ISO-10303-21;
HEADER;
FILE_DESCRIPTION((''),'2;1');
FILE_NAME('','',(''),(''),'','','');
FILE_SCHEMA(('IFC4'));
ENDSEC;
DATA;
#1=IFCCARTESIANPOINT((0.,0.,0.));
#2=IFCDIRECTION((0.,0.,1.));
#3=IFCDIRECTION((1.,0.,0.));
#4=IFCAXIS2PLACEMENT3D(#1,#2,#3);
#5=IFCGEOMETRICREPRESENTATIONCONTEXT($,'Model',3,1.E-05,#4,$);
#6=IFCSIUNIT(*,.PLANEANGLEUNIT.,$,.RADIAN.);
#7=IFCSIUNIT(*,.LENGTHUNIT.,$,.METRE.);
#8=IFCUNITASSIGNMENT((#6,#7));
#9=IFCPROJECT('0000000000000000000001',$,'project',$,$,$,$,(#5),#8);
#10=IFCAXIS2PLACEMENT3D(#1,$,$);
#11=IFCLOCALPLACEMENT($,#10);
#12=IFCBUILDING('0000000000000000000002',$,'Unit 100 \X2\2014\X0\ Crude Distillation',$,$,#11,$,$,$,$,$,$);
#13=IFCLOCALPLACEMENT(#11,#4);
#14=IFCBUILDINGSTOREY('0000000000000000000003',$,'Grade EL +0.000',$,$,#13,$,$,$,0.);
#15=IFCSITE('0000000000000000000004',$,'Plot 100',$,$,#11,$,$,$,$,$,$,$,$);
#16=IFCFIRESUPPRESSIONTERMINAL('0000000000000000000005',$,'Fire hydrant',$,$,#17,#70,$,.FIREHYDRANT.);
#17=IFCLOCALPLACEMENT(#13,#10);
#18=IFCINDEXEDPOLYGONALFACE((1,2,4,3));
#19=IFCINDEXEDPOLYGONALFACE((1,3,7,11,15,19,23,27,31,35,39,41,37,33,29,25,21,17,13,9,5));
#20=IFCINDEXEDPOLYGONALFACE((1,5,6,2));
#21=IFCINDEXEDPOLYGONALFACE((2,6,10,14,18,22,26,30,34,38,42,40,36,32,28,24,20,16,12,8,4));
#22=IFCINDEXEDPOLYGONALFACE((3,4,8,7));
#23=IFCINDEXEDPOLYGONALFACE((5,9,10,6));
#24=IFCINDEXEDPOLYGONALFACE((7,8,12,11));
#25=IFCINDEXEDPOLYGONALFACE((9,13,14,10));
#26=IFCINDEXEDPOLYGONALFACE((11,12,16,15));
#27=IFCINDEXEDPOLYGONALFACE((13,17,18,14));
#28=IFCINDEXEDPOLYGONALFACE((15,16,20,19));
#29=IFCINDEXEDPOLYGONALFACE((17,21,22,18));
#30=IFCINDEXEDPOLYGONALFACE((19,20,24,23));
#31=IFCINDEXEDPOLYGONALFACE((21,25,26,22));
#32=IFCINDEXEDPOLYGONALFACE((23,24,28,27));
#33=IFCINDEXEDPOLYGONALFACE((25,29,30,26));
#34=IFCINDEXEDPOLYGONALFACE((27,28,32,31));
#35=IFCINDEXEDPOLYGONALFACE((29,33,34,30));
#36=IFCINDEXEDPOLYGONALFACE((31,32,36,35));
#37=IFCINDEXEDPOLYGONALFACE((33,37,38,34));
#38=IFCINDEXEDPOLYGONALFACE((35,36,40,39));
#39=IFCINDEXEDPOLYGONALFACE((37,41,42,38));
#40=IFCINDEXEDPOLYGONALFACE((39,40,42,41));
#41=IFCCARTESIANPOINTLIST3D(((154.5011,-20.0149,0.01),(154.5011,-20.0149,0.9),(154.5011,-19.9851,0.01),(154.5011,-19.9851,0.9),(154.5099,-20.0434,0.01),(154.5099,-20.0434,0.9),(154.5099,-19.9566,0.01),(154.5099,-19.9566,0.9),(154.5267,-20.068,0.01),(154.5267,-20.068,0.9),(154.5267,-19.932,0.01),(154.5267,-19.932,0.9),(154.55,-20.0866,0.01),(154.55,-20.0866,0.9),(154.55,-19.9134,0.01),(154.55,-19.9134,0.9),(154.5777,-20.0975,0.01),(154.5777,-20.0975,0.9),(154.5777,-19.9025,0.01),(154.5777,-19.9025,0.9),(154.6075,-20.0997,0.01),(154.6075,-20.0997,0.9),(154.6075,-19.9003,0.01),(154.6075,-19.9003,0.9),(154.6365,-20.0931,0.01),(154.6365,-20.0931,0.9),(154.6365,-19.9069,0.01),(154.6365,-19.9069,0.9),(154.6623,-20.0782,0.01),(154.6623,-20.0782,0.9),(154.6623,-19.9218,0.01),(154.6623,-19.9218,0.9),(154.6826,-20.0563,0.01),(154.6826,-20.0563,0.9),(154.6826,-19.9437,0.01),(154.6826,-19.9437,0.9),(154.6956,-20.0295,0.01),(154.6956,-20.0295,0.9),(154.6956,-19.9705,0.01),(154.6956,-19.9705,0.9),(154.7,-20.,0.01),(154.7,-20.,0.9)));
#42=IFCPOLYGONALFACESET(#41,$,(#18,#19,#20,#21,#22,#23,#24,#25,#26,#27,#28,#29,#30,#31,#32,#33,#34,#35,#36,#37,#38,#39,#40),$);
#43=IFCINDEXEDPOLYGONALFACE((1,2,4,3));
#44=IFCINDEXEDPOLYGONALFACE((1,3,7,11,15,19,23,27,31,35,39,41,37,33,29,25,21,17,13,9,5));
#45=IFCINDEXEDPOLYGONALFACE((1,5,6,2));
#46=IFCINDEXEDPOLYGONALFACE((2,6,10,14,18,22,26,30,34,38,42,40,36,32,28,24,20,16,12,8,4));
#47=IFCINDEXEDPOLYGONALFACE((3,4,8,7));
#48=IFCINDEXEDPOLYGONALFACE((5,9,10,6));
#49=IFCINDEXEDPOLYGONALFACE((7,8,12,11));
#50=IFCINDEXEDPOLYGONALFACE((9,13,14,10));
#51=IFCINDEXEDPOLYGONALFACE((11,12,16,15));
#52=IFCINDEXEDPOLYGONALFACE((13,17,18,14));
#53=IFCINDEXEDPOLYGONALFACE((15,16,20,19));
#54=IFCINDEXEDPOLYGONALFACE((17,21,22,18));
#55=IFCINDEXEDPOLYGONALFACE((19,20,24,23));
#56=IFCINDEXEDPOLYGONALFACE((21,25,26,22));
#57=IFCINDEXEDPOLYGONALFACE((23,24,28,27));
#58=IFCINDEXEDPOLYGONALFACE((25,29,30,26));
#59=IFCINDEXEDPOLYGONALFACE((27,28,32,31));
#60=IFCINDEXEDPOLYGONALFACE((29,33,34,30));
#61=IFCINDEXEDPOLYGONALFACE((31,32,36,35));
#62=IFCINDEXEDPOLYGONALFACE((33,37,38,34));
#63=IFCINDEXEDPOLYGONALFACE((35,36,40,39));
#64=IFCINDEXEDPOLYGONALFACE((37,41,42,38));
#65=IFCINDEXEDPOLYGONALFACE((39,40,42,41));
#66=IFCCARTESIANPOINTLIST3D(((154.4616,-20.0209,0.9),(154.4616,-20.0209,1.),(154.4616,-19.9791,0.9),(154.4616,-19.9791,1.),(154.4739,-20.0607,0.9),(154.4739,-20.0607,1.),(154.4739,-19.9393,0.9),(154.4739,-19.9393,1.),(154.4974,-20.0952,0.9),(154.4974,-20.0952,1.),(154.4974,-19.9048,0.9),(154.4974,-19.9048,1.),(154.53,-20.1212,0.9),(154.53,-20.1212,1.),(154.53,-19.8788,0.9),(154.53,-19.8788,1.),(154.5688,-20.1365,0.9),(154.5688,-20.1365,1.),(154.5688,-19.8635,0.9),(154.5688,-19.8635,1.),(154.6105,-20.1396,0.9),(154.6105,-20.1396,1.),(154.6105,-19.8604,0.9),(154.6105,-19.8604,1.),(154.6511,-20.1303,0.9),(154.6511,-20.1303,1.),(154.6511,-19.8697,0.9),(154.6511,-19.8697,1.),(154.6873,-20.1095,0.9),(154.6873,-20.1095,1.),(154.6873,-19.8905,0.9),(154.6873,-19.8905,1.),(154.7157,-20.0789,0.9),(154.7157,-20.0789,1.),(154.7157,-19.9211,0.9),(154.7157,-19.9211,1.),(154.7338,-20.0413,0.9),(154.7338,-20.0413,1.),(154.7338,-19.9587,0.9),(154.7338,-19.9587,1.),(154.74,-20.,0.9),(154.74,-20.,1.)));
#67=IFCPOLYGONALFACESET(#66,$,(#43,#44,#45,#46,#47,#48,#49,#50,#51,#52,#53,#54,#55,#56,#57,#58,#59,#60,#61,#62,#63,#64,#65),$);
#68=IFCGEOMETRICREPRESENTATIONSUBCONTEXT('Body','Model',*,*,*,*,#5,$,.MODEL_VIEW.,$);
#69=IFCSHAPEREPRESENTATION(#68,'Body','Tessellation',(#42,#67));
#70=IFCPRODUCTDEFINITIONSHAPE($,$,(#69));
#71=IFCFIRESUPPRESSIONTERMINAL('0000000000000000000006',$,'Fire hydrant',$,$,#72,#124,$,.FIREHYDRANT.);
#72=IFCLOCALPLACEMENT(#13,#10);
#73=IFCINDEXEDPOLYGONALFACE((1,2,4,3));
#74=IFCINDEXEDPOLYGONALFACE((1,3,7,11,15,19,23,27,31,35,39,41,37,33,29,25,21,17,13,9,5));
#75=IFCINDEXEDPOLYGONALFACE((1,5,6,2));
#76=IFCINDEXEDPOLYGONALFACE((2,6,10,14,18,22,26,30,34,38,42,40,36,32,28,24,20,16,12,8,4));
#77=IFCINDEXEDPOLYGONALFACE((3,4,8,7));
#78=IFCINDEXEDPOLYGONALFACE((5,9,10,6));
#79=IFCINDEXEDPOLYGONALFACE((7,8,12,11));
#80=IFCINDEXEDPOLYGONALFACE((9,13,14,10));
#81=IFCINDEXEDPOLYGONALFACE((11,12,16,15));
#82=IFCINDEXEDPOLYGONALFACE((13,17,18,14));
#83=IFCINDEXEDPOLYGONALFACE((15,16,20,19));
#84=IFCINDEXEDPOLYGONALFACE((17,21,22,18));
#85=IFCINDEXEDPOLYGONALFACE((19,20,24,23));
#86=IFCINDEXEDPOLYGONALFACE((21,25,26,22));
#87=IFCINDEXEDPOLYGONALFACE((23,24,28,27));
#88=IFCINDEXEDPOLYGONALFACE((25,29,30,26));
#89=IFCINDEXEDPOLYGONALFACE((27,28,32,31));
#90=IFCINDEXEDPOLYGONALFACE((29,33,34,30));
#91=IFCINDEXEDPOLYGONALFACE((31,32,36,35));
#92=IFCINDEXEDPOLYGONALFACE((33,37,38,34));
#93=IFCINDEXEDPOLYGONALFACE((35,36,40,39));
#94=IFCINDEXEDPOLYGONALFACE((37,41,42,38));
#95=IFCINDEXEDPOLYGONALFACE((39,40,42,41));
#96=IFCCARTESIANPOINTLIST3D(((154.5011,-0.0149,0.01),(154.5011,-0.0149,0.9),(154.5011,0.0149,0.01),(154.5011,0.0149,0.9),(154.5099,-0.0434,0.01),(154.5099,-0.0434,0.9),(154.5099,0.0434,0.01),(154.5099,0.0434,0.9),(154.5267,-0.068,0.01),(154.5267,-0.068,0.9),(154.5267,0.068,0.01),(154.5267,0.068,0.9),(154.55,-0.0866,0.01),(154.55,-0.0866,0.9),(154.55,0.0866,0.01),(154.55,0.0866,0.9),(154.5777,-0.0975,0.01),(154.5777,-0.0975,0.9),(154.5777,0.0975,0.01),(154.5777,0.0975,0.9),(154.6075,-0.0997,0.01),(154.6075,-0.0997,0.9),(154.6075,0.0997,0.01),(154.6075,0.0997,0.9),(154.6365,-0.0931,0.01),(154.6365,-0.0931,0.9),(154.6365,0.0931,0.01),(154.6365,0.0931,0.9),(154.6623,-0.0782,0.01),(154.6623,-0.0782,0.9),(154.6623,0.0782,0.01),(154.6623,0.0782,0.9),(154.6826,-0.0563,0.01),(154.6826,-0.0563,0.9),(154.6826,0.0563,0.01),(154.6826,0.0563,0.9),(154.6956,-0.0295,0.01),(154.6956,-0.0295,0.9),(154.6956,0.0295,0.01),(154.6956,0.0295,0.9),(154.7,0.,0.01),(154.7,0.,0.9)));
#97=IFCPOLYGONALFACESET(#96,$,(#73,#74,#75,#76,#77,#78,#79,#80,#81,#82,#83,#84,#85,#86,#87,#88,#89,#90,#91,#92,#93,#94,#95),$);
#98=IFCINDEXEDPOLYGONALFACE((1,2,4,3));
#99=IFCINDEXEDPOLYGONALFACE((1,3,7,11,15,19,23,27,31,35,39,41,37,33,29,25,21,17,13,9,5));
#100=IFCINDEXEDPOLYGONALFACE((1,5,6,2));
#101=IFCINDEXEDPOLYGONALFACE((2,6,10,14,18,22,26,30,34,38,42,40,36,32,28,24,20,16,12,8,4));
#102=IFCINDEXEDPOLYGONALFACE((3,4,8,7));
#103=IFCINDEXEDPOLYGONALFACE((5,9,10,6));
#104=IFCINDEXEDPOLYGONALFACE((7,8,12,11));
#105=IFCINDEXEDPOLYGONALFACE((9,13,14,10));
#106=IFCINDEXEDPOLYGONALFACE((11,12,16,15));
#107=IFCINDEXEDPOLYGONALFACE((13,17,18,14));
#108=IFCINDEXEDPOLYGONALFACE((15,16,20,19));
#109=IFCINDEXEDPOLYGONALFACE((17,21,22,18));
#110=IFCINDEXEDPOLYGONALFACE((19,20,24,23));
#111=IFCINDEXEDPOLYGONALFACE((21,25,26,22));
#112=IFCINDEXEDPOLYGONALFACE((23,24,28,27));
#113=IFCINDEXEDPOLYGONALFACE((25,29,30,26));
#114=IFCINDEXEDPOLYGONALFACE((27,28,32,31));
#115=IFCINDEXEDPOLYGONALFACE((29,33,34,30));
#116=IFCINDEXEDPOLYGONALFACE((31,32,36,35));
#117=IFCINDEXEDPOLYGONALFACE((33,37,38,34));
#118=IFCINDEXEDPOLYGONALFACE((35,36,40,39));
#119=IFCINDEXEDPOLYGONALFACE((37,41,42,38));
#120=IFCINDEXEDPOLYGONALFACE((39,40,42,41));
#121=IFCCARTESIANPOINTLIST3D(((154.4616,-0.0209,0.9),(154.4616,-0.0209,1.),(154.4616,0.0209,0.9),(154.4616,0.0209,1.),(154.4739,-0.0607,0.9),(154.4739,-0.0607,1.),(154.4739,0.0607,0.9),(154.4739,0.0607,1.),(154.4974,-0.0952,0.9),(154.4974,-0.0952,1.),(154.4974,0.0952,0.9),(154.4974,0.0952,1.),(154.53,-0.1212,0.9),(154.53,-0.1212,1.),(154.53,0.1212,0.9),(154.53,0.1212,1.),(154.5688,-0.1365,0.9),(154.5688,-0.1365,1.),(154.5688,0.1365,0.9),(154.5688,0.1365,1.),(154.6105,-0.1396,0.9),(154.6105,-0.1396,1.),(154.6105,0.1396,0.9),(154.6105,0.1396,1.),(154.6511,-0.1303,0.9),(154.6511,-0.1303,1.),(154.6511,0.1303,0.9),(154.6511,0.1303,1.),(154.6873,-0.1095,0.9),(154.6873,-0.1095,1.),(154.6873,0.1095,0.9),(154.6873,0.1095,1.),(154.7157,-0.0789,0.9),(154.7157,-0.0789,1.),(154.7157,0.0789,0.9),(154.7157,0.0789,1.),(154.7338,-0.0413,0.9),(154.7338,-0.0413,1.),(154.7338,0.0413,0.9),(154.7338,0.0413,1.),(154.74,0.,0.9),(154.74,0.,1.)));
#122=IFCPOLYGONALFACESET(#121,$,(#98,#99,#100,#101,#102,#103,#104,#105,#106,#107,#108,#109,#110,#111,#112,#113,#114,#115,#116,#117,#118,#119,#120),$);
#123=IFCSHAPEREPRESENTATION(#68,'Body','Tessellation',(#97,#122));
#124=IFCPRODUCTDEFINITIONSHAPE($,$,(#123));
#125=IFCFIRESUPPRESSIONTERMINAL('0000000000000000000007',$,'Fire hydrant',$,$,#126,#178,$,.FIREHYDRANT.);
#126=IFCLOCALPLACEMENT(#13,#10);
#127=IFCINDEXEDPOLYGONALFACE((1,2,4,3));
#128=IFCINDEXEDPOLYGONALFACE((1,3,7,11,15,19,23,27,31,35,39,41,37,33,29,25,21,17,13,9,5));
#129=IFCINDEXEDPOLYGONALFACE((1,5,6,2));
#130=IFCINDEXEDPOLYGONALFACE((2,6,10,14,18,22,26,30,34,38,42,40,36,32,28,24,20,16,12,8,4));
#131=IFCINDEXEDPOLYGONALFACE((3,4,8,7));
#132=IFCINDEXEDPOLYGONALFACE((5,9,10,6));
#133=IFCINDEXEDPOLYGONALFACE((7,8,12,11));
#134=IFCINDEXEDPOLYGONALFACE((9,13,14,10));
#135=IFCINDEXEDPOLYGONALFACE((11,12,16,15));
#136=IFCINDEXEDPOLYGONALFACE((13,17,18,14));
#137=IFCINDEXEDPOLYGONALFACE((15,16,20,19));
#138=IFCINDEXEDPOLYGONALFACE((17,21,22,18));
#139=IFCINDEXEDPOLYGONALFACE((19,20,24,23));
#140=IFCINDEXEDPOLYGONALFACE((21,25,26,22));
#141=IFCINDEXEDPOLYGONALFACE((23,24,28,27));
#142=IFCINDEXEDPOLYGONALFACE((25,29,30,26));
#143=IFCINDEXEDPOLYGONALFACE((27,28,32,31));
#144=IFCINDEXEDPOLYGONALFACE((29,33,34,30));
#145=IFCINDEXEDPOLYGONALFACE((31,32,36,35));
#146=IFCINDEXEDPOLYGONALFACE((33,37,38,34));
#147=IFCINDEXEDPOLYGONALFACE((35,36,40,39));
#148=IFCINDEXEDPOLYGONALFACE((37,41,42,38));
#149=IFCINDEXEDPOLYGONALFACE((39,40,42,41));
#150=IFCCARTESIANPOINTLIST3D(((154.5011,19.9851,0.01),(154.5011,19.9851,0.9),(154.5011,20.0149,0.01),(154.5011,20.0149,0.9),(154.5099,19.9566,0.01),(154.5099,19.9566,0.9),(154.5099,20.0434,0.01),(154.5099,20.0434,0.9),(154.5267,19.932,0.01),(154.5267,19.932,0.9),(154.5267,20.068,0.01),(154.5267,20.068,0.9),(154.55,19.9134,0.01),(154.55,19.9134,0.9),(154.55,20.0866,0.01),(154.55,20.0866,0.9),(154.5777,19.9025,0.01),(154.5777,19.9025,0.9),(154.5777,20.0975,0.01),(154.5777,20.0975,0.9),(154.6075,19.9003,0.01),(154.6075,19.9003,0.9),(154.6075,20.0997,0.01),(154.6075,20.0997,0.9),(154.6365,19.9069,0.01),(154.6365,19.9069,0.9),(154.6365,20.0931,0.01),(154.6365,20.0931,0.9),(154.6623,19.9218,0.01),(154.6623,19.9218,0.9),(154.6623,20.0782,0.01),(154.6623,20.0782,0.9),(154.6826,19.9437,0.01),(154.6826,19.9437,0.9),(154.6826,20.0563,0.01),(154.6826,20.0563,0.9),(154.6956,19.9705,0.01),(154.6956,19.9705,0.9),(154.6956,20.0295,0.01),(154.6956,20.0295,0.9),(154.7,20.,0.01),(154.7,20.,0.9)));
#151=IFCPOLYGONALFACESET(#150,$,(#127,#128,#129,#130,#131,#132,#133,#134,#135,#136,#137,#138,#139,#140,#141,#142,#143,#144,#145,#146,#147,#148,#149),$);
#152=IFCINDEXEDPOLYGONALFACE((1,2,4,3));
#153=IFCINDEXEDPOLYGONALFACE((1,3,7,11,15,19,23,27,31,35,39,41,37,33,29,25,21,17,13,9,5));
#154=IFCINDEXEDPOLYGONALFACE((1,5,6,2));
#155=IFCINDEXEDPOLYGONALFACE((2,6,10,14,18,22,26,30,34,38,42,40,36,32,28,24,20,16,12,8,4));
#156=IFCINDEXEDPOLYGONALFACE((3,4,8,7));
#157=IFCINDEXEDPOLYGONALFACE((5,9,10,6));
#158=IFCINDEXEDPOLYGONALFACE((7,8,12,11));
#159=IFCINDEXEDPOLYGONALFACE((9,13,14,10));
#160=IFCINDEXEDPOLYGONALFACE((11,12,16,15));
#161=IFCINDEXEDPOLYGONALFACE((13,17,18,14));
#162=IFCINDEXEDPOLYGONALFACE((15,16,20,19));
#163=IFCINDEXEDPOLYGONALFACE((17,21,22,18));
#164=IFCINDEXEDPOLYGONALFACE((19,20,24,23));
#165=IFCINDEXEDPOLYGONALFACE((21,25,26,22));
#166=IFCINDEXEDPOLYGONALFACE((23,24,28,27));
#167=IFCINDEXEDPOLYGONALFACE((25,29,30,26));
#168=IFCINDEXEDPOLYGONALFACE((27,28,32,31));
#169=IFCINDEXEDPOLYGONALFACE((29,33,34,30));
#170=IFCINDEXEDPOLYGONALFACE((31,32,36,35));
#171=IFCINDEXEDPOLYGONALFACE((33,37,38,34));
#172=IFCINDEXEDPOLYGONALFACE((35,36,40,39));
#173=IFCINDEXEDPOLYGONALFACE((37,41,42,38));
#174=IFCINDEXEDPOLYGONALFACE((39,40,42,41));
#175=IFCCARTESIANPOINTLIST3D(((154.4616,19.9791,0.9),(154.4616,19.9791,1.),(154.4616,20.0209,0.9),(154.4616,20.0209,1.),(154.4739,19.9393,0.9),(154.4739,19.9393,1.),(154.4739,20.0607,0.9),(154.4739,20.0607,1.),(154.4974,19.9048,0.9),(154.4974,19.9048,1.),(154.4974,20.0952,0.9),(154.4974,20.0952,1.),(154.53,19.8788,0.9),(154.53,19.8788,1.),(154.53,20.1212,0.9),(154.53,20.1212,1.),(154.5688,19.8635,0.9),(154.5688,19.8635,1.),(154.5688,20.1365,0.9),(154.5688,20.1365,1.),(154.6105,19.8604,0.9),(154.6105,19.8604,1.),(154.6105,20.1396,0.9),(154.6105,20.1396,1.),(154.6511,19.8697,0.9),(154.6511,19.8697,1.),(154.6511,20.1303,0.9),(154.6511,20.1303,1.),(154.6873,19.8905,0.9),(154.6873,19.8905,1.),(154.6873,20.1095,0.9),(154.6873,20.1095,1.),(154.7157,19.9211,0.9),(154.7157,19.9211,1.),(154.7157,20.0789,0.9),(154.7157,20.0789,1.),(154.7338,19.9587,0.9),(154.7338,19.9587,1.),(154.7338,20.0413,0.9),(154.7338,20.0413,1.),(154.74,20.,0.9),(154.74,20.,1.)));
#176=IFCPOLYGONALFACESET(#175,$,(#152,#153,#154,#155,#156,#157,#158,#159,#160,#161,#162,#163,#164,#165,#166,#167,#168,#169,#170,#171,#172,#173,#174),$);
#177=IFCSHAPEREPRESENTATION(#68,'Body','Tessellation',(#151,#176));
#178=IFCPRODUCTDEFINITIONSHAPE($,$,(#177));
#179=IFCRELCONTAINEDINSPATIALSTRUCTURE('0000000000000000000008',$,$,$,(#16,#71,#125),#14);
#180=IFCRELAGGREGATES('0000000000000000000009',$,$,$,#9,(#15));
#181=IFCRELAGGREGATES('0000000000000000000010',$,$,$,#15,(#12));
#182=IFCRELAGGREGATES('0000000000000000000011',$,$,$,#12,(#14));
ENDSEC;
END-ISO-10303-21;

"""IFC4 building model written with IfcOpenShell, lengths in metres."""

from ifc_helpers import new_model, si_unit, frame, origin, origin_with_axes, origin_2d, place, context, subcontext, project, spatial, circle, extrude, element, save


model = new_model("IFC4")

# Units and contexts
model_context = context("Model", 3, precision=1e-05, world=origin_with_axes())
body_context = subcontext(model_context, "Body", "Model", "MODEL_VIEW")
ifc_project = project(units=[si_unit("PLANEANGLEUNIT", "RADIAN"), si_unit("LENGTHUNIT", "METRE")], contexts=[model_context])

# Site, building, storey
placement = place(None, origin())
site = spatial("IfcSite", under=ifc_project, at=placement, Name="Plot 100")
building = spatial("IfcBuilding", under=site, at=placement, Name="Unit 100 — Crude Distillation")
storey_placement = place(placement, origin_with_axes())
storey = spatial("IfcBuildingStorey", under=building, at=storey_placement, Name="Grade EL +0.000", Elevation=0.0)

# Fire suppression terminals
fire_suppression_terminal_1_placement = place(storey_placement, origin_with_axes())
element("IfcFireSuppressionTerminal", 1, at=fire_suppression_terminal_1_placement, inside=storey, Name="Fire hydrant", PredefinedType="FIREHYDRANT", context=body_context, shape_type="SweptSolid", body=[
    extrude(circle(Radius=0.1, at=origin_2d()), frame((154.6, -20.0, 0.01), z_axis=(0.0, 0.0, 1.0), x_axis=(1.0, 0.0, 0.0)), (0.0, 0.0, 1.0), 0.89),
    extrude(circle(Radius=0.14, at=origin_2d()), frame((154.6, -20.0, 0.9), z_axis=(0.0, 0.0, 1.0), x_axis=(1.0, 0.0, 0.0)), (0.0, 0.0, 1.0), 0.1),
])
fire_suppression_terminal_2_placement = place(storey_placement, origin_with_axes())
element("IfcFireSuppressionTerminal", 2, at=fire_suppression_terminal_2_placement, inside=storey, Name="Fire hydrant", PredefinedType="FIREHYDRANT", context=body_context, shape_type="SweptSolid", body=[
    extrude(circle(Radius=0.1, at=origin_2d()), frame((154.6, 0.0, 0.01), z_axis=(0.0, 0.0, 1.0), x_axis=(1.0, 0.0, 0.0)), (0.0, 0.0, 1.0), 0.89),
    extrude(circle(Radius=0.14, at=origin_2d()), frame((154.6, 0.0, 0.9), z_axis=(0.0, 0.0, 1.0), x_axis=(1.0, 0.0, 0.0)), (0.0, 0.0, 1.0), 0.1),
])
fire_suppression_terminal_3_placement = place(storey_placement, origin_with_axes())
element("IfcFireSuppressionTerminal", 3, at=fire_suppression_terminal_3_placement, inside=storey, Name="Fire hydrant", PredefinedType="FIREHYDRANT", context=body_context, shape_type="SweptSolid", body=[
    extrude(circle(Radius=0.1, at=origin_2d()), frame((154.6, 20.0, 0.01), z_axis=(0.0, 0.0, 1.0), x_axis=(1.0, 0.0, 0.0)), (0.0, 0.0, 1.0), 0.89),
    extrude(circle(Radius=0.14, at=origin_2d()), frame((154.6, 20.0, 0.9), z_axis=(0.0, 0.0, 1.0), x_axis=(1.0, 0.0, 0.0)), (0.0, 0.0, 1.0), 0.1),
])

save(model, "model.ifc")
